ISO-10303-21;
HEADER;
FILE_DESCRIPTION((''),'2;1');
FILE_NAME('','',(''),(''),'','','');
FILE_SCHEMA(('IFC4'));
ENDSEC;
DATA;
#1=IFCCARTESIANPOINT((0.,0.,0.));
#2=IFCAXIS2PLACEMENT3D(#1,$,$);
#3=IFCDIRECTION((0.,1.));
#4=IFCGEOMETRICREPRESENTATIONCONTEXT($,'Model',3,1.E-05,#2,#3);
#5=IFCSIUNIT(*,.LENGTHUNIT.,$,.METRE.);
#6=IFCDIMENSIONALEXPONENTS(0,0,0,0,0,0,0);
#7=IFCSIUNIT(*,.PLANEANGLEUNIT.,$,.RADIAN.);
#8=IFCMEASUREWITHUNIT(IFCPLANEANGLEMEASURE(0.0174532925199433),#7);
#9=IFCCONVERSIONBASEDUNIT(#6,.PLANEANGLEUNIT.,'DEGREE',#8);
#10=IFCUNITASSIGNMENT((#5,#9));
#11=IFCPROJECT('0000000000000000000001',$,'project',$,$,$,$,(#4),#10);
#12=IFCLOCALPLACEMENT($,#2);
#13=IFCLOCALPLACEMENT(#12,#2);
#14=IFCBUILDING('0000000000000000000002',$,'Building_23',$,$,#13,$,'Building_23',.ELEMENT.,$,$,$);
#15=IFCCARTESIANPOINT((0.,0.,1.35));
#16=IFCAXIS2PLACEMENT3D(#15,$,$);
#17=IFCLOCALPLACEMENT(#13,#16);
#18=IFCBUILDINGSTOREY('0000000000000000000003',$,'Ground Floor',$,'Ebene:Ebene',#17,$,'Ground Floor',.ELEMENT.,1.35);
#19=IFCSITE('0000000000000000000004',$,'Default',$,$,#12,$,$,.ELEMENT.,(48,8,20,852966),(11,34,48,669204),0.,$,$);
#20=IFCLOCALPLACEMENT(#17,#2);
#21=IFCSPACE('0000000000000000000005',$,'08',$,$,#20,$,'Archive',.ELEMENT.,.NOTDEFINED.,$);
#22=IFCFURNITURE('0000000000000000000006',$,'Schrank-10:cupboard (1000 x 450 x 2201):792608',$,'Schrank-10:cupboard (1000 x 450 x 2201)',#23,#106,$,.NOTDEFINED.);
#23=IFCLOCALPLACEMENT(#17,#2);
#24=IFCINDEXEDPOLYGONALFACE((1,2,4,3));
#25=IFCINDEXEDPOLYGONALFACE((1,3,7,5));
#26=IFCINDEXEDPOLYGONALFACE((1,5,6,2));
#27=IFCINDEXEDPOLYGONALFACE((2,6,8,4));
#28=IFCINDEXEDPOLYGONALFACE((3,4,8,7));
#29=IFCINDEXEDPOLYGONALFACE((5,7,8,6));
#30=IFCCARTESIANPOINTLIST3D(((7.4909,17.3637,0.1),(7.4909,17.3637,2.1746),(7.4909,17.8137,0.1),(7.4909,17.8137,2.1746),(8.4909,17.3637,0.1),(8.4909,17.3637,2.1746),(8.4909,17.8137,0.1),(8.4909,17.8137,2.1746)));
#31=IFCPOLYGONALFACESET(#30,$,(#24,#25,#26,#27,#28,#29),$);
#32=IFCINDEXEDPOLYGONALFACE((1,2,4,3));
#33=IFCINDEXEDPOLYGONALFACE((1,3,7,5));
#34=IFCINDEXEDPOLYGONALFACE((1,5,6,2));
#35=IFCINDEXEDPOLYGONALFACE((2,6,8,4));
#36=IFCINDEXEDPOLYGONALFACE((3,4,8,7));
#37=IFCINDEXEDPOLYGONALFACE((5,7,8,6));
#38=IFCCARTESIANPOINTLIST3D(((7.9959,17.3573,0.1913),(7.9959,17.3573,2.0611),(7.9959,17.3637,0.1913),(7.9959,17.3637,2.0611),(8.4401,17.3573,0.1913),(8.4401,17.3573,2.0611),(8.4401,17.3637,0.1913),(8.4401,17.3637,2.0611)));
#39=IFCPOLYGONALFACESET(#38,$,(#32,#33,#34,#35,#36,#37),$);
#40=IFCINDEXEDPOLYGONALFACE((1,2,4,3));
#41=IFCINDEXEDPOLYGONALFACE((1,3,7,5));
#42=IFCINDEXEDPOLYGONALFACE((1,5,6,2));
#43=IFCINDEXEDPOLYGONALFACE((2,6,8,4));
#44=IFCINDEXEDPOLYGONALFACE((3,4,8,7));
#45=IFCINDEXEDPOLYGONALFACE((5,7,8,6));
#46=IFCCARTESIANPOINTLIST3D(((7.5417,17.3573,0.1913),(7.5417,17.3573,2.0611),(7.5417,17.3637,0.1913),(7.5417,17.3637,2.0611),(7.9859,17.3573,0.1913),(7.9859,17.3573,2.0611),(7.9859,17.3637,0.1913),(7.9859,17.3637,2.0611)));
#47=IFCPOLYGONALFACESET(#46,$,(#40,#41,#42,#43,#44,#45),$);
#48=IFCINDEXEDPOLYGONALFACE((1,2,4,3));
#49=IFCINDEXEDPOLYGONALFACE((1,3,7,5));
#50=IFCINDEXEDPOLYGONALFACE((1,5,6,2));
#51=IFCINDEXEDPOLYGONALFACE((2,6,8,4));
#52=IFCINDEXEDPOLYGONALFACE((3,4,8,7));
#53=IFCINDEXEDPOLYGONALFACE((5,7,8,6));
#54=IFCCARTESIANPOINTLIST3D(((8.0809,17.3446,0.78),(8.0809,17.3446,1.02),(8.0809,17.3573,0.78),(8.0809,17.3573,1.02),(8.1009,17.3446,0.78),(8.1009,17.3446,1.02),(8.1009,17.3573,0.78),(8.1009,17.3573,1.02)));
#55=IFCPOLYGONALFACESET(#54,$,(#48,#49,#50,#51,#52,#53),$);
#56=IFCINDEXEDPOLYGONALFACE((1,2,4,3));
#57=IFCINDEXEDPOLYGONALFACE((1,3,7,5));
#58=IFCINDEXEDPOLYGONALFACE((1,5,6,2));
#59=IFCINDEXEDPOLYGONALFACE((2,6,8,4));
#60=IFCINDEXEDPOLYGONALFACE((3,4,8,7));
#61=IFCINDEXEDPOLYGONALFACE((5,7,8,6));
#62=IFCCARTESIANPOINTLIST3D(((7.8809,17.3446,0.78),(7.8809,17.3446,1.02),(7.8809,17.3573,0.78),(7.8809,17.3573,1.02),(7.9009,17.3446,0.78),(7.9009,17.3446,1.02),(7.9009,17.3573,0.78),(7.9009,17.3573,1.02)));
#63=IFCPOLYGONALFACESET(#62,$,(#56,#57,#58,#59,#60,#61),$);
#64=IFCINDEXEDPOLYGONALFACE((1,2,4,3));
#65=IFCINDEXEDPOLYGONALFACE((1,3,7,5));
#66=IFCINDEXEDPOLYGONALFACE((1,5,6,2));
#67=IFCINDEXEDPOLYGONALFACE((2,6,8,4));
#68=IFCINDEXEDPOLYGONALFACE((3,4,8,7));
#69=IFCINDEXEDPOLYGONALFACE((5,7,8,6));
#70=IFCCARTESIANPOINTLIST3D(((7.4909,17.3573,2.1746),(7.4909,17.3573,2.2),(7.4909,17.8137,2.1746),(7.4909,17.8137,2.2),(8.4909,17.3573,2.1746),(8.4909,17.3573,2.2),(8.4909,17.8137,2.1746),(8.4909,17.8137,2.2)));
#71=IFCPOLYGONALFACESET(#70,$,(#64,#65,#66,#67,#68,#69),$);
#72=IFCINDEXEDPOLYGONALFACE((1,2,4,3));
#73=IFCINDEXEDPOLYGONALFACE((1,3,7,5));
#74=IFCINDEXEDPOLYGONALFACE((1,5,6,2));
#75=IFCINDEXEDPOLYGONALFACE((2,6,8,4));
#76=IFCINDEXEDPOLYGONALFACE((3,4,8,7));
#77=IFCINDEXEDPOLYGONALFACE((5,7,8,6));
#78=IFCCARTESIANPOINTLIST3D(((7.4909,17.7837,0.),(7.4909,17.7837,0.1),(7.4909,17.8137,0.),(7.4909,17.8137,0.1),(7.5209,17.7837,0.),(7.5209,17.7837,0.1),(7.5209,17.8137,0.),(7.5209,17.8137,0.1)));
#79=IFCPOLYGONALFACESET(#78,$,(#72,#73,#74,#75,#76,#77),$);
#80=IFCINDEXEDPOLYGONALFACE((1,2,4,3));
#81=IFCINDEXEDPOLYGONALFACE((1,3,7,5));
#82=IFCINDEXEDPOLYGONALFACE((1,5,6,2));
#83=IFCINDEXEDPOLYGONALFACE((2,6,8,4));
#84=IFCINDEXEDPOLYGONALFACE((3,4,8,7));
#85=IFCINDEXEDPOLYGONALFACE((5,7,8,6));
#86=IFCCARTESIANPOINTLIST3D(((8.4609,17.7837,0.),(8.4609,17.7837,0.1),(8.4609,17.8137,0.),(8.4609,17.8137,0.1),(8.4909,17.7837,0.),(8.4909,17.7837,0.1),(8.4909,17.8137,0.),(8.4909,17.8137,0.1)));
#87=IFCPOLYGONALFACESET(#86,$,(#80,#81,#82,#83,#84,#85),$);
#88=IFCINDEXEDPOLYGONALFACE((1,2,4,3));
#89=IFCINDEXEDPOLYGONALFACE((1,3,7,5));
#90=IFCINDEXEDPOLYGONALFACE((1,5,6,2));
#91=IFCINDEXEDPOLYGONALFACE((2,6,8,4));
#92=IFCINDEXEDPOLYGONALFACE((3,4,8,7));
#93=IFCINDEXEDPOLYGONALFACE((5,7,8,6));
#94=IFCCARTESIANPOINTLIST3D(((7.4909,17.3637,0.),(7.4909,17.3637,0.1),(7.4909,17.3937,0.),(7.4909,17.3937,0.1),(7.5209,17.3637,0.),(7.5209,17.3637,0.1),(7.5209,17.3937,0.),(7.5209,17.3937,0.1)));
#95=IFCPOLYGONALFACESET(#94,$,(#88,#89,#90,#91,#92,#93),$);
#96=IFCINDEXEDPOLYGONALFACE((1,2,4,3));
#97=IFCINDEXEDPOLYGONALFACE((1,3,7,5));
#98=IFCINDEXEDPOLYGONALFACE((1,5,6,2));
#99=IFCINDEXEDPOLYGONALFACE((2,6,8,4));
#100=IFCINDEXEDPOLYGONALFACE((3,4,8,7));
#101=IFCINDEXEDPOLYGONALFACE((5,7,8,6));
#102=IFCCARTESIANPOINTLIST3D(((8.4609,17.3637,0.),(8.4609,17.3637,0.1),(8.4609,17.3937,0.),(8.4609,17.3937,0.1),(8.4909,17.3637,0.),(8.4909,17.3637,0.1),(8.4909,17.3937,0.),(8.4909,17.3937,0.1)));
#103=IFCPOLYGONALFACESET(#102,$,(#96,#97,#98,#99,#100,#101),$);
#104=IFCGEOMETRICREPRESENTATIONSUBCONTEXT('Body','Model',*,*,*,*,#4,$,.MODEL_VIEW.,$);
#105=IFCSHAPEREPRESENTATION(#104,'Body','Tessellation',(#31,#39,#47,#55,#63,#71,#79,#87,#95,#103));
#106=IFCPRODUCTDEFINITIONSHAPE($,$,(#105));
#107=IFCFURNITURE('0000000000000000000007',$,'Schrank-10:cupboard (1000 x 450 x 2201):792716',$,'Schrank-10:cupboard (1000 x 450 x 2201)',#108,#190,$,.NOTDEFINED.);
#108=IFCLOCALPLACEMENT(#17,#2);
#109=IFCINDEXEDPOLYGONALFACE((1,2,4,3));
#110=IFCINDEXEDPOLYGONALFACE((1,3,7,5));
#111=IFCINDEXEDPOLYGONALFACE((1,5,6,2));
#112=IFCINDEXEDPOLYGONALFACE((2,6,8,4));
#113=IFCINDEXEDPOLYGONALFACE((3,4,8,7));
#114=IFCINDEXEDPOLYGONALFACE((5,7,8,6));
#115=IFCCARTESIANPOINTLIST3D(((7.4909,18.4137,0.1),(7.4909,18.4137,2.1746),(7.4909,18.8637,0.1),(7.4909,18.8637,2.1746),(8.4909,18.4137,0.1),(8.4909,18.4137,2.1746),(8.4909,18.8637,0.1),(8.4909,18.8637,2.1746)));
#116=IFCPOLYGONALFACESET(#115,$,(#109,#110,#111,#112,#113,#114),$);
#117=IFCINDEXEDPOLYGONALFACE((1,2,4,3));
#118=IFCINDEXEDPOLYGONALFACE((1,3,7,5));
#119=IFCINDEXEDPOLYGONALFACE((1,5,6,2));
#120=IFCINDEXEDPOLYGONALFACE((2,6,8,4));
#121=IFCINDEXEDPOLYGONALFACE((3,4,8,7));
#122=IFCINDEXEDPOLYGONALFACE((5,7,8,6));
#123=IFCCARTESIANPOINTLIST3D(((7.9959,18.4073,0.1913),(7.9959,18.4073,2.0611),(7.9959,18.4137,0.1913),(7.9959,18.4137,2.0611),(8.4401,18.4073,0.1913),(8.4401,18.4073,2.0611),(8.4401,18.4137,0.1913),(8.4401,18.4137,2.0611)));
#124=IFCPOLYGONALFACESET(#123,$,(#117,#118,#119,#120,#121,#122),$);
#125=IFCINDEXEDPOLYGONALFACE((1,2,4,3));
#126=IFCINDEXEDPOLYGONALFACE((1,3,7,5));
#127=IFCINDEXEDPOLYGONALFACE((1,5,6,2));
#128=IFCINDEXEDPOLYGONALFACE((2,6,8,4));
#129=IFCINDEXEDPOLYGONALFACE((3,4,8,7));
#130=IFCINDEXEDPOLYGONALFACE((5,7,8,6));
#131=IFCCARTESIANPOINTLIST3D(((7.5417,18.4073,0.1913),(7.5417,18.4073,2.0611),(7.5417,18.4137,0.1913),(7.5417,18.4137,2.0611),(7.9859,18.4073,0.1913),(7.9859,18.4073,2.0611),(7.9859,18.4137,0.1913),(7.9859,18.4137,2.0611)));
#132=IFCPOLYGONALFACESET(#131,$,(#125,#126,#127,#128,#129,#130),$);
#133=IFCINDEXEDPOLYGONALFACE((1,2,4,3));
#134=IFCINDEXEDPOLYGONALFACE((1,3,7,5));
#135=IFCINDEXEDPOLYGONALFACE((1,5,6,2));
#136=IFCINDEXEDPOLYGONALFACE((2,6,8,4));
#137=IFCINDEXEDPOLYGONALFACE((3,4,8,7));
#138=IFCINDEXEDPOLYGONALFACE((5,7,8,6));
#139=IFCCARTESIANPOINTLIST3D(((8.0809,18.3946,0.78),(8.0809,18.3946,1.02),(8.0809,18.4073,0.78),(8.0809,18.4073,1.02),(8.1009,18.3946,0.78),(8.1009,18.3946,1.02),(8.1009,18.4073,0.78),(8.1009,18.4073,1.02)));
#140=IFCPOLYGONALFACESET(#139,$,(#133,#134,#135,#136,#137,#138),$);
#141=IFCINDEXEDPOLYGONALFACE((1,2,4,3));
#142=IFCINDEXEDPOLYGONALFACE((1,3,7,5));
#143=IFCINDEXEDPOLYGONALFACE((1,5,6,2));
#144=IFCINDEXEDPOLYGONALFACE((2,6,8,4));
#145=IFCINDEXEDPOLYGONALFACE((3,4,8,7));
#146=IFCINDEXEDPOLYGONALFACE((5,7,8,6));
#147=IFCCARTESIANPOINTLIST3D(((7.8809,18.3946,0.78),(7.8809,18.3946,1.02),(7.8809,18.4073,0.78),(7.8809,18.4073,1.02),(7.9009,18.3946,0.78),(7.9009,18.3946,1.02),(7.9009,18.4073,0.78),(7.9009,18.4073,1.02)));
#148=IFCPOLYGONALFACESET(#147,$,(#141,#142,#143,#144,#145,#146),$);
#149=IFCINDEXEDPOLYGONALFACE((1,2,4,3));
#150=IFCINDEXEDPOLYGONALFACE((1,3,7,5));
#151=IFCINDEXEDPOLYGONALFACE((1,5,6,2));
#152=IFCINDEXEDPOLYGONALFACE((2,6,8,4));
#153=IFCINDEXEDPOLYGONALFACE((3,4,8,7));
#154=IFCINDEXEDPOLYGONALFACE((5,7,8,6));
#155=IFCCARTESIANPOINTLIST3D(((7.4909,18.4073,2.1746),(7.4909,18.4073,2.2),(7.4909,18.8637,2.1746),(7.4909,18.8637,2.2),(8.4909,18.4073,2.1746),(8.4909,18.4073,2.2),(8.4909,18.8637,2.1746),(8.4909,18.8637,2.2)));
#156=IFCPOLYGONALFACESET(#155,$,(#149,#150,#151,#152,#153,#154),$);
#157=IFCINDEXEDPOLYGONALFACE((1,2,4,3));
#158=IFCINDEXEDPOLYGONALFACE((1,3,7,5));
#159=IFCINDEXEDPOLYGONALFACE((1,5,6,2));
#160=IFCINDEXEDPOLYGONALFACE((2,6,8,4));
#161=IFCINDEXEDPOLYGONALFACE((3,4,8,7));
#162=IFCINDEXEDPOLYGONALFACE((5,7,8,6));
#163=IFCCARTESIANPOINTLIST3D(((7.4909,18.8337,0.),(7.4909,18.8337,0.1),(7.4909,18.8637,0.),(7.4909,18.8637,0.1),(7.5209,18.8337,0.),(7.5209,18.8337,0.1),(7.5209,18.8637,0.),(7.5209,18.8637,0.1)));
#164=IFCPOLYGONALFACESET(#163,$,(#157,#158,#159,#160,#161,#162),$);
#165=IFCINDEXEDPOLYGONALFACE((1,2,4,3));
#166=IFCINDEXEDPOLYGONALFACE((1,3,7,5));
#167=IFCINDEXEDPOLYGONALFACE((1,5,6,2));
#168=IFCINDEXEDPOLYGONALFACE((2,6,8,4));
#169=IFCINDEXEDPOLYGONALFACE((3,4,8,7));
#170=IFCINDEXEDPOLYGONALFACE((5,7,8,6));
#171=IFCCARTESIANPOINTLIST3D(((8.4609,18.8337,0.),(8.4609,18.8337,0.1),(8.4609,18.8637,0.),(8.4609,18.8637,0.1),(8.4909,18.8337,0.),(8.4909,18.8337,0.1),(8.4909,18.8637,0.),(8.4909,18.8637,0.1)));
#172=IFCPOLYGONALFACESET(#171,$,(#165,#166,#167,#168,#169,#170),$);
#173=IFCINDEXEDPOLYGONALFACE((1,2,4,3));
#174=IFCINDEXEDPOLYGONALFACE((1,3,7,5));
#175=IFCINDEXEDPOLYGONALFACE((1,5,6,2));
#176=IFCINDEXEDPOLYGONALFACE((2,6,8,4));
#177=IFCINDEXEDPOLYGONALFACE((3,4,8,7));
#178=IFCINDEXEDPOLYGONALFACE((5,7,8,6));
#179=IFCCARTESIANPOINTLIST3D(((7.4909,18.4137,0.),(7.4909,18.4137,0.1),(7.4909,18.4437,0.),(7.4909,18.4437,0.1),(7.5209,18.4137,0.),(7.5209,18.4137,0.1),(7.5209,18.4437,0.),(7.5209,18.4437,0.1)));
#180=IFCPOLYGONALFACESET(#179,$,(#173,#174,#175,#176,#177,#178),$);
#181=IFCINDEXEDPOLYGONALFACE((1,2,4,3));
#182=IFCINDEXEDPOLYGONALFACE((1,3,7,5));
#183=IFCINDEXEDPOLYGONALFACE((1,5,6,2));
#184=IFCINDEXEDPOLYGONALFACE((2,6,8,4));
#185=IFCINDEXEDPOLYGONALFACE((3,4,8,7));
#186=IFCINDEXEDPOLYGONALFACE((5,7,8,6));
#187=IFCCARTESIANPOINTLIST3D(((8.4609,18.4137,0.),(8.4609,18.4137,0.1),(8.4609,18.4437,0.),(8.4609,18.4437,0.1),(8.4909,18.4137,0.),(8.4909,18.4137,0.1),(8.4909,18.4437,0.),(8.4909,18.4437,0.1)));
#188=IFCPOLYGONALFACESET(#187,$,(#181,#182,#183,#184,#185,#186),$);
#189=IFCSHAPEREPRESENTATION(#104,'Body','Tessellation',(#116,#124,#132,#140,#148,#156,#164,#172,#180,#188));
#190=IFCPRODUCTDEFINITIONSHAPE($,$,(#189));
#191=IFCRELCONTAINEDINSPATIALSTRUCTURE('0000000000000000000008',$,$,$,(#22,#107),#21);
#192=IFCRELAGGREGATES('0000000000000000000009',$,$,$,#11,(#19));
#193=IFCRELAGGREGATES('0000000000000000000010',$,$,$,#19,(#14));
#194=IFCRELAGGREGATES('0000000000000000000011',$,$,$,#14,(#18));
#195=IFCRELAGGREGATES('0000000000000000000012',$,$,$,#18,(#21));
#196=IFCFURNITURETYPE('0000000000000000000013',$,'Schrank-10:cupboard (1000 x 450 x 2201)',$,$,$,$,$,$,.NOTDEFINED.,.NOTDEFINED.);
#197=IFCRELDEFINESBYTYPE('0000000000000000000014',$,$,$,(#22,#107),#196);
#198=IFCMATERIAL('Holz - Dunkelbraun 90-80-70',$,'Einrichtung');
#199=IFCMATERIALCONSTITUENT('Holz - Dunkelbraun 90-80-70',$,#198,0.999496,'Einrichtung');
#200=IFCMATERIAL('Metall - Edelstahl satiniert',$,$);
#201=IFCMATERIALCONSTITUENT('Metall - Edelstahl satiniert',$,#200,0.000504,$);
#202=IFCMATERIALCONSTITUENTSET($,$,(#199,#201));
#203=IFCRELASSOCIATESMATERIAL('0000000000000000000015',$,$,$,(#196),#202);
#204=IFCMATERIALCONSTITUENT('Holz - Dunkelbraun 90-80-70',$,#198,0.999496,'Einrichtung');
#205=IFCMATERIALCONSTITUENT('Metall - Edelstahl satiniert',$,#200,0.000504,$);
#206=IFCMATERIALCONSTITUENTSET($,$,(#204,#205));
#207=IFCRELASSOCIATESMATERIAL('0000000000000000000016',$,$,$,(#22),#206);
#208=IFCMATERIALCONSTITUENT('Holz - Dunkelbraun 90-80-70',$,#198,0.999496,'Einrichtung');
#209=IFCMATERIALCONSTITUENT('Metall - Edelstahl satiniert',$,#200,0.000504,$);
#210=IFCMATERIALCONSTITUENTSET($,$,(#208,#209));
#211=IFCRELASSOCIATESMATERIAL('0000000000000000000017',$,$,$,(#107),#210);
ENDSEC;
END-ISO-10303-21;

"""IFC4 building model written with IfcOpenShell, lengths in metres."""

from ifc_helpers import new_model, entity, si_unit, converted_unit, direction, frame, origin, place, context, subcontext, project, spatial, indexed_curve, outline, extrude, source, transform, mapped, material, constituent, constituent_set, type_object, type_shapes, element, save


model = new_model("IFC4")

# Units and contexts
model_context = context("Model", 3, precision=1e-05, world=origin(), true_north=direction((0.0, 1.0)))
body_context = subcontext(model_context, "Body", "Model", "MODEL_VIEW")
ifc_project = project(units=[si_unit("LENGTHUNIT", "METRE"), converted_unit("PLANEANGLEUNIT", "DEGREE", entity("IfcPlaneAngleMeasure", 0.0174532925199433), si_unit("PLANEANGLEUNIT", "RADIAN"), dimensions=[0, 0, 0, 0, 0, 0, 0])], contexts=[model_context])

# Site, building, storey
site_placement = place(None, origin())
site = spatial("IfcSite", under=ifc_project, at=site_placement, Name="Default", CompositionType="ELEMENT", RefLatitude=(48, 8, 20, 852966), RefLongitude=(11, 34, 48, 669204), RefElevation=0.0)
building_placement = place(site_placement, origin())
building = spatial("IfcBuilding", under=site, at=building_placement, Name="Building_23", LongName="Building_23", CompositionType="ELEMENT")
storey_placement = place(building_placement, frame((0.0, 0.0, 1.35)))
storey = spatial("IfcBuildingStorey", under=building, at=storey_placement, Name="Ground Floor", ObjectType="Ebene:Ebene", LongName="Ground Floor", CompositionType="ELEMENT", Elevation=1.35)

# Shared definitions
space_placement = place(storey_placement, origin())
space = spatial("IfcSpace", under=storey, at=space_placement, Name="08", LongName="Archive", CompositionType="ELEMENT", PredefinedType="NOTDEFINED")

# Furniture
ifc_material_1 = material(Name="Holz - Dunkelbraun 90-80-70", Category="Einrichtung")
ifc_material_2 = material(Name="Metall - Edelstahl satiniert")
ifc_constituent_1 = constituent(ifc_material_1, Name="Holz - Dunkelbraun 90-80-70", Category="Einrichtung", fraction=0.999496)
ifc_constituent_2 = constituent(ifc_material_2, Name="Metall - Edelstahl satiniert", fraction=0.000504)
ifc_constituent_set_1 = constituent_set(constituents=[ifc_constituent_1, ifc_constituent_2])
furniture_type = type_object("IfcFurnitureType", Name="Schrank-10:cupboard (1000 x 450 x 2201)", AssemblyPlace="NOTDEFINED", PredefinedType="NOTDEFINED", material=ifc_constituent_set_1)
shared_shape_1 = source(origin(), body_context, "Body", "SweptSolid", [
    extrude(outline(indexed_curve([(-0.225, -0.5), (0.225, -0.5), (0.225, 0.5), (-0.225, 0.5), (-0.225, -0.5)], self_intersect=False)), frame((-0.2692, -0.3632, 0.1), z_axis=(0.0, 0.0, 1.0), x_axis=(0.0, 1.0, 0.0)), (0.0, 0.0, 1.0), 2.0746),
    extrude(outline(indexed_curve([(-0.0032, -0.2221), (0.0032, -0.2221), (0.0032, 0.2221), (-0.0032, 0.2221), (-0.0032, -0.2221)], self_intersect=False)), frame((-0.0421, -0.5913, 0.1913), z_axis=(0.0, 0.0, 1.0), x_axis=(0.0, 1.0, 0.0)), (0.0, 0.0, 1.0), 1.8698),
    extrude(outline(indexed_curve([(-0.0032, -0.2221), (0.0032, -0.2221), (0.0032, 0.2221), (-0.0032, 0.2221), (-0.0032, -0.2221)], self_intersect=False)), frame((-0.4963, -0.5913, 0.1913), z_axis=(0.0, 0.0, 1.0), x_axis=(0.0, 1.0, 0.0)), (0.0, 0.0, 1.0), 1.8698),
    extrude(outline(indexed_curve([(-0.0063, -0.01), (0.0063, -0.01), (0.0063, 0.01), (-0.0063, 0.01), (-0.0063, -0.01)], self_intersect=False)), frame((-0.1692, -0.6009, 0.78), z_axis=(0.0, 0.0, 1.0), x_axis=(0.0, 1.0, 0.0)), (0.0, 0.0, 1.0), 0.24),
    extrude(outline(indexed_curve([(-0.0063, -0.01), (0.0063, -0.01), (0.0063, 0.01), (-0.0063, 0.01), (-0.0063, -0.01)], self_intersect=False)), frame((-0.3692, -0.6009, 0.78), z_axis=(0.0, 0.0, 1.0), x_axis=(0.0, 1.0, 0.0)), (0.0, 0.0, 1.0), 0.24),
    extrude(outline(indexed_curve([(-0.5, -0.2282), (0.5, -0.2282), (0.5, 0.2282), (-0.5, 0.2282), (-0.5, -0.2282)], self_intersect=False)), frame((-0.2692, -0.3663, 2.1746), z_axis=(0.0, 0.0, 1.0), x_axis=(-1.0, 0.0, 0.0)), (0.0, 0.0, 1.0), 0.0254),
    extrude(outline(indexed_curve([(-0.015, -0.015), (0.015, -0.015), (0.015, 0.015), (-0.015, 0.015), (-0.015, -0.015)], self_intersect=False)), frame((-0.7542, -0.1532, 0.0), z_axis=(0.0, 0.0, 1.0), x_axis=(-1.0, 0.0, 0.0)), (0.0, 0.0, 1.0), 0.1),
    extrude(outline(indexed_curve([(-0.015, -0.015), (0.015, -0.015), (0.015, 0.015), (-0.015, 0.015), (-0.015, -0.015)], self_intersect=False)), frame((0.2158, -0.1532, 0.0), z_axis=(0.0, 0.0, 1.0), x_axis=(0.0, -1.0, 0.0)), (0.0, 0.0, 1.0), 0.1),
    extrude(outline(indexed_curve([(-0.015, -0.015), (0.015, -0.015), (0.015, 0.015), (-0.015, 0.015), (-0.015, -0.015)], self_intersect=False)), frame((-0.7542, -0.5732, 0.0), z_axis=(0.0, 0.0, 1.0), x_axis=(0.0, 1.0, 0.0)), (0.0, 0.0, 1.0), 0.1),
    extrude(outline(indexed_curve([(-0.015, -0.015), (0.015, -0.015), (0.015, 0.015), (-0.015, 0.015), (-0.015, -0.015)], self_intersect=False)), frame((0.2158, -0.5732, 0.0)), (0.0, 0.0, 1.0), 0.1),
])
type_shapes(furniture_type, [shared_shape_1])
ifc_constituent_3 = constituent(ifc_material_1, Name="Holz - Dunkelbraun 90-80-70", Category="Einrichtung", fraction=0.999496)
ifc_constituent_4 = constituent(ifc_material_2, Name="Metall - Edelstahl satiniert", fraction=0.000504)
ifc_constituent_set_2 = constituent_set(constituents=[ifc_constituent_3, ifc_constituent_4])
furniture_1_placement = place(space_placement, frame((8.2601, 17.9519, 0.0)))
element("IfcFurniture", 1, at=furniture_1_placement, inside=space, type_object=furniture_type, material=ifc_constituent_set_2, Name="Schrank-10:cupboard (1000 x 450 x 2201):792608", ObjectType="Schrank-10:cupboard (1000 x 450 x 2201)", PredefinedType="NOTDEFINED", context=body_context, shape_type="MappedRepresentation", body=[
    mapped(shared_shape_1, transform((0.0, 0.0, 0.0), scale=1.0)),
])
ifc_constituent_5 = constituent(ifc_material_1, Name="Holz - Dunkelbraun 90-80-70", Category="Einrichtung", fraction=0.999496)
ifc_constituent_6 = constituent(ifc_material_2, Name="Metall - Edelstahl satiniert", fraction=0.000504)
ifc_constituent_set_3 = constituent_set(constituents=[ifc_constituent_5, ifc_constituent_6])
furniture_2_placement = place(space_placement, frame((8.2601, 19.0019, 0.0)))
element("IfcFurniture", 2, at=furniture_2_placement, inside=space, type_object=furniture_type, material=ifc_constituent_set_3, Name="Schrank-10:cupboard (1000 x 450 x 2201):792716", ObjectType="Schrank-10:cupboard (1000 x 450 x 2201)", PredefinedType="NOTDEFINED", context=body_context, shape_type="MappedRepresentation", body=[
    mapped(shared_shape_1, transform((0.0, 0.0, 0.0), scale=1.0)),
])

save(model, "model.ifc")
